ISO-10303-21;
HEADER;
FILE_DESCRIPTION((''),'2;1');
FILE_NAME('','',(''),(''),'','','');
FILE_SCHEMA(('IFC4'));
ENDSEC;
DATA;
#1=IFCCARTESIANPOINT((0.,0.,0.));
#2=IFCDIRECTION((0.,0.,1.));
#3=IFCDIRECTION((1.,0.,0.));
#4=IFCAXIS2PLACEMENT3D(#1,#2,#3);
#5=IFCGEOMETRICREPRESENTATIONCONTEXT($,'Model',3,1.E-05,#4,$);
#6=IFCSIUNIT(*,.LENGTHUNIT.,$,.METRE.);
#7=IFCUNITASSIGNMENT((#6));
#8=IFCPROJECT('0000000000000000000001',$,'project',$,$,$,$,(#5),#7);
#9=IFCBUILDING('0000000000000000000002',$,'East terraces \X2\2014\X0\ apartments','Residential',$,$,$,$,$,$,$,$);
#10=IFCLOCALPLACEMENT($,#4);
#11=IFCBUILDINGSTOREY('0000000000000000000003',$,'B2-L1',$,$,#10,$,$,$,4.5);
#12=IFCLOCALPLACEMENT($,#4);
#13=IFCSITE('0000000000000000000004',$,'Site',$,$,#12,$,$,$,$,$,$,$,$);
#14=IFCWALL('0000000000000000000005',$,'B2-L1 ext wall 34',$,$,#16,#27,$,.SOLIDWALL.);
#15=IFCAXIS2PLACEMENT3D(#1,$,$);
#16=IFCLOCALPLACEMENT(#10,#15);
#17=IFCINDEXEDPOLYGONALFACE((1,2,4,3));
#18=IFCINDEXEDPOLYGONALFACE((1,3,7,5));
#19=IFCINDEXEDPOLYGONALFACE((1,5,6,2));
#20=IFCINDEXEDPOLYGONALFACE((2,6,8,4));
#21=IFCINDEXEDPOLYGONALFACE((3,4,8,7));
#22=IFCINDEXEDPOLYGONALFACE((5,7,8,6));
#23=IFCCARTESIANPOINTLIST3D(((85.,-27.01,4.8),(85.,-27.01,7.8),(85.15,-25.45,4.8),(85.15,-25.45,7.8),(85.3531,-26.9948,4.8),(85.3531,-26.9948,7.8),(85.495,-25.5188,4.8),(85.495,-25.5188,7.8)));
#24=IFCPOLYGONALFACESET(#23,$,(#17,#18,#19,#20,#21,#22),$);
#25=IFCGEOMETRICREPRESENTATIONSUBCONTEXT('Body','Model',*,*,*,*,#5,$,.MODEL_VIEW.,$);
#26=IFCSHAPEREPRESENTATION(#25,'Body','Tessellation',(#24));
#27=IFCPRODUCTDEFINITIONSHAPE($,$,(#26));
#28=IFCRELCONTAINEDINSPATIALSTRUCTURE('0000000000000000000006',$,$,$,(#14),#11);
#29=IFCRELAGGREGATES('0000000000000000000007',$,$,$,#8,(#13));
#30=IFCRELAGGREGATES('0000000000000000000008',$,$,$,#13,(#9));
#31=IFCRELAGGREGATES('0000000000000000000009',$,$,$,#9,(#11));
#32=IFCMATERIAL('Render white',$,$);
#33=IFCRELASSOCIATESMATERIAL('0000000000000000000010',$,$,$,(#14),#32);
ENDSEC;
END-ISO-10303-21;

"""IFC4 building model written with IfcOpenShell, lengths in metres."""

from ifc_helpers import new_model, si_unit, frame, origin_with_axes, place, context, subcontext, project, spatial, polyline, outline, extrude, material, element, save


model = new_model("IFC4")

# Units and contexts
model_context = context("Model", 3, precision=1e-05, world=origin_with_axes())
body_context = subcontext(model_context, "Body", "Model", "MODEL_VIEW")
ifc_project = project(units=[si_unit("LENGTHUNIT", "METRE")], contexts=[model_context])

# Site, building, storey
site_placement = place(None, origin_with_axes())
site = spatial("IfcSite", under=ifc_project, at=site_placement, Name="Site")
building = spatial("IfcBuilding", under=site, Name="East terraces — apartments", Description="Residential")
storey_placement = place(None, origin_with_axes())
storey = spatial("IfcBuildingStorey", under=building, at=storey_placement, Name="B2-L1", Elevation=4.5)

# Shared definitions
ifc_material_1 = material(Name="Render white")

# Wall
wall_1_placement = place(storey_placement, origin_with_axes())
element("IfcWall", 1, at=wall_1_placement, inside=storey, material=ifc_material_1, Name="B2-L1 ext wall 34", PredefinedType="SOLIDWALL", context=body_context, shape_type="SweptSolid", body=[
    extrude(outline(polyline([(85.15, -25.45), (85.0, -27.01), (85.3531, -26.9948), (85.495, -25.5188), (85.15, -25.45)])), frame((0.0, 0.0, 4.8), z_axis=(0.0, 0.0, 1.0), x_axis=(1.0, 0.0, 0.0)), (0.0, 0.0, 1.0), 3.0),
])

save(model, "model.ifc")
